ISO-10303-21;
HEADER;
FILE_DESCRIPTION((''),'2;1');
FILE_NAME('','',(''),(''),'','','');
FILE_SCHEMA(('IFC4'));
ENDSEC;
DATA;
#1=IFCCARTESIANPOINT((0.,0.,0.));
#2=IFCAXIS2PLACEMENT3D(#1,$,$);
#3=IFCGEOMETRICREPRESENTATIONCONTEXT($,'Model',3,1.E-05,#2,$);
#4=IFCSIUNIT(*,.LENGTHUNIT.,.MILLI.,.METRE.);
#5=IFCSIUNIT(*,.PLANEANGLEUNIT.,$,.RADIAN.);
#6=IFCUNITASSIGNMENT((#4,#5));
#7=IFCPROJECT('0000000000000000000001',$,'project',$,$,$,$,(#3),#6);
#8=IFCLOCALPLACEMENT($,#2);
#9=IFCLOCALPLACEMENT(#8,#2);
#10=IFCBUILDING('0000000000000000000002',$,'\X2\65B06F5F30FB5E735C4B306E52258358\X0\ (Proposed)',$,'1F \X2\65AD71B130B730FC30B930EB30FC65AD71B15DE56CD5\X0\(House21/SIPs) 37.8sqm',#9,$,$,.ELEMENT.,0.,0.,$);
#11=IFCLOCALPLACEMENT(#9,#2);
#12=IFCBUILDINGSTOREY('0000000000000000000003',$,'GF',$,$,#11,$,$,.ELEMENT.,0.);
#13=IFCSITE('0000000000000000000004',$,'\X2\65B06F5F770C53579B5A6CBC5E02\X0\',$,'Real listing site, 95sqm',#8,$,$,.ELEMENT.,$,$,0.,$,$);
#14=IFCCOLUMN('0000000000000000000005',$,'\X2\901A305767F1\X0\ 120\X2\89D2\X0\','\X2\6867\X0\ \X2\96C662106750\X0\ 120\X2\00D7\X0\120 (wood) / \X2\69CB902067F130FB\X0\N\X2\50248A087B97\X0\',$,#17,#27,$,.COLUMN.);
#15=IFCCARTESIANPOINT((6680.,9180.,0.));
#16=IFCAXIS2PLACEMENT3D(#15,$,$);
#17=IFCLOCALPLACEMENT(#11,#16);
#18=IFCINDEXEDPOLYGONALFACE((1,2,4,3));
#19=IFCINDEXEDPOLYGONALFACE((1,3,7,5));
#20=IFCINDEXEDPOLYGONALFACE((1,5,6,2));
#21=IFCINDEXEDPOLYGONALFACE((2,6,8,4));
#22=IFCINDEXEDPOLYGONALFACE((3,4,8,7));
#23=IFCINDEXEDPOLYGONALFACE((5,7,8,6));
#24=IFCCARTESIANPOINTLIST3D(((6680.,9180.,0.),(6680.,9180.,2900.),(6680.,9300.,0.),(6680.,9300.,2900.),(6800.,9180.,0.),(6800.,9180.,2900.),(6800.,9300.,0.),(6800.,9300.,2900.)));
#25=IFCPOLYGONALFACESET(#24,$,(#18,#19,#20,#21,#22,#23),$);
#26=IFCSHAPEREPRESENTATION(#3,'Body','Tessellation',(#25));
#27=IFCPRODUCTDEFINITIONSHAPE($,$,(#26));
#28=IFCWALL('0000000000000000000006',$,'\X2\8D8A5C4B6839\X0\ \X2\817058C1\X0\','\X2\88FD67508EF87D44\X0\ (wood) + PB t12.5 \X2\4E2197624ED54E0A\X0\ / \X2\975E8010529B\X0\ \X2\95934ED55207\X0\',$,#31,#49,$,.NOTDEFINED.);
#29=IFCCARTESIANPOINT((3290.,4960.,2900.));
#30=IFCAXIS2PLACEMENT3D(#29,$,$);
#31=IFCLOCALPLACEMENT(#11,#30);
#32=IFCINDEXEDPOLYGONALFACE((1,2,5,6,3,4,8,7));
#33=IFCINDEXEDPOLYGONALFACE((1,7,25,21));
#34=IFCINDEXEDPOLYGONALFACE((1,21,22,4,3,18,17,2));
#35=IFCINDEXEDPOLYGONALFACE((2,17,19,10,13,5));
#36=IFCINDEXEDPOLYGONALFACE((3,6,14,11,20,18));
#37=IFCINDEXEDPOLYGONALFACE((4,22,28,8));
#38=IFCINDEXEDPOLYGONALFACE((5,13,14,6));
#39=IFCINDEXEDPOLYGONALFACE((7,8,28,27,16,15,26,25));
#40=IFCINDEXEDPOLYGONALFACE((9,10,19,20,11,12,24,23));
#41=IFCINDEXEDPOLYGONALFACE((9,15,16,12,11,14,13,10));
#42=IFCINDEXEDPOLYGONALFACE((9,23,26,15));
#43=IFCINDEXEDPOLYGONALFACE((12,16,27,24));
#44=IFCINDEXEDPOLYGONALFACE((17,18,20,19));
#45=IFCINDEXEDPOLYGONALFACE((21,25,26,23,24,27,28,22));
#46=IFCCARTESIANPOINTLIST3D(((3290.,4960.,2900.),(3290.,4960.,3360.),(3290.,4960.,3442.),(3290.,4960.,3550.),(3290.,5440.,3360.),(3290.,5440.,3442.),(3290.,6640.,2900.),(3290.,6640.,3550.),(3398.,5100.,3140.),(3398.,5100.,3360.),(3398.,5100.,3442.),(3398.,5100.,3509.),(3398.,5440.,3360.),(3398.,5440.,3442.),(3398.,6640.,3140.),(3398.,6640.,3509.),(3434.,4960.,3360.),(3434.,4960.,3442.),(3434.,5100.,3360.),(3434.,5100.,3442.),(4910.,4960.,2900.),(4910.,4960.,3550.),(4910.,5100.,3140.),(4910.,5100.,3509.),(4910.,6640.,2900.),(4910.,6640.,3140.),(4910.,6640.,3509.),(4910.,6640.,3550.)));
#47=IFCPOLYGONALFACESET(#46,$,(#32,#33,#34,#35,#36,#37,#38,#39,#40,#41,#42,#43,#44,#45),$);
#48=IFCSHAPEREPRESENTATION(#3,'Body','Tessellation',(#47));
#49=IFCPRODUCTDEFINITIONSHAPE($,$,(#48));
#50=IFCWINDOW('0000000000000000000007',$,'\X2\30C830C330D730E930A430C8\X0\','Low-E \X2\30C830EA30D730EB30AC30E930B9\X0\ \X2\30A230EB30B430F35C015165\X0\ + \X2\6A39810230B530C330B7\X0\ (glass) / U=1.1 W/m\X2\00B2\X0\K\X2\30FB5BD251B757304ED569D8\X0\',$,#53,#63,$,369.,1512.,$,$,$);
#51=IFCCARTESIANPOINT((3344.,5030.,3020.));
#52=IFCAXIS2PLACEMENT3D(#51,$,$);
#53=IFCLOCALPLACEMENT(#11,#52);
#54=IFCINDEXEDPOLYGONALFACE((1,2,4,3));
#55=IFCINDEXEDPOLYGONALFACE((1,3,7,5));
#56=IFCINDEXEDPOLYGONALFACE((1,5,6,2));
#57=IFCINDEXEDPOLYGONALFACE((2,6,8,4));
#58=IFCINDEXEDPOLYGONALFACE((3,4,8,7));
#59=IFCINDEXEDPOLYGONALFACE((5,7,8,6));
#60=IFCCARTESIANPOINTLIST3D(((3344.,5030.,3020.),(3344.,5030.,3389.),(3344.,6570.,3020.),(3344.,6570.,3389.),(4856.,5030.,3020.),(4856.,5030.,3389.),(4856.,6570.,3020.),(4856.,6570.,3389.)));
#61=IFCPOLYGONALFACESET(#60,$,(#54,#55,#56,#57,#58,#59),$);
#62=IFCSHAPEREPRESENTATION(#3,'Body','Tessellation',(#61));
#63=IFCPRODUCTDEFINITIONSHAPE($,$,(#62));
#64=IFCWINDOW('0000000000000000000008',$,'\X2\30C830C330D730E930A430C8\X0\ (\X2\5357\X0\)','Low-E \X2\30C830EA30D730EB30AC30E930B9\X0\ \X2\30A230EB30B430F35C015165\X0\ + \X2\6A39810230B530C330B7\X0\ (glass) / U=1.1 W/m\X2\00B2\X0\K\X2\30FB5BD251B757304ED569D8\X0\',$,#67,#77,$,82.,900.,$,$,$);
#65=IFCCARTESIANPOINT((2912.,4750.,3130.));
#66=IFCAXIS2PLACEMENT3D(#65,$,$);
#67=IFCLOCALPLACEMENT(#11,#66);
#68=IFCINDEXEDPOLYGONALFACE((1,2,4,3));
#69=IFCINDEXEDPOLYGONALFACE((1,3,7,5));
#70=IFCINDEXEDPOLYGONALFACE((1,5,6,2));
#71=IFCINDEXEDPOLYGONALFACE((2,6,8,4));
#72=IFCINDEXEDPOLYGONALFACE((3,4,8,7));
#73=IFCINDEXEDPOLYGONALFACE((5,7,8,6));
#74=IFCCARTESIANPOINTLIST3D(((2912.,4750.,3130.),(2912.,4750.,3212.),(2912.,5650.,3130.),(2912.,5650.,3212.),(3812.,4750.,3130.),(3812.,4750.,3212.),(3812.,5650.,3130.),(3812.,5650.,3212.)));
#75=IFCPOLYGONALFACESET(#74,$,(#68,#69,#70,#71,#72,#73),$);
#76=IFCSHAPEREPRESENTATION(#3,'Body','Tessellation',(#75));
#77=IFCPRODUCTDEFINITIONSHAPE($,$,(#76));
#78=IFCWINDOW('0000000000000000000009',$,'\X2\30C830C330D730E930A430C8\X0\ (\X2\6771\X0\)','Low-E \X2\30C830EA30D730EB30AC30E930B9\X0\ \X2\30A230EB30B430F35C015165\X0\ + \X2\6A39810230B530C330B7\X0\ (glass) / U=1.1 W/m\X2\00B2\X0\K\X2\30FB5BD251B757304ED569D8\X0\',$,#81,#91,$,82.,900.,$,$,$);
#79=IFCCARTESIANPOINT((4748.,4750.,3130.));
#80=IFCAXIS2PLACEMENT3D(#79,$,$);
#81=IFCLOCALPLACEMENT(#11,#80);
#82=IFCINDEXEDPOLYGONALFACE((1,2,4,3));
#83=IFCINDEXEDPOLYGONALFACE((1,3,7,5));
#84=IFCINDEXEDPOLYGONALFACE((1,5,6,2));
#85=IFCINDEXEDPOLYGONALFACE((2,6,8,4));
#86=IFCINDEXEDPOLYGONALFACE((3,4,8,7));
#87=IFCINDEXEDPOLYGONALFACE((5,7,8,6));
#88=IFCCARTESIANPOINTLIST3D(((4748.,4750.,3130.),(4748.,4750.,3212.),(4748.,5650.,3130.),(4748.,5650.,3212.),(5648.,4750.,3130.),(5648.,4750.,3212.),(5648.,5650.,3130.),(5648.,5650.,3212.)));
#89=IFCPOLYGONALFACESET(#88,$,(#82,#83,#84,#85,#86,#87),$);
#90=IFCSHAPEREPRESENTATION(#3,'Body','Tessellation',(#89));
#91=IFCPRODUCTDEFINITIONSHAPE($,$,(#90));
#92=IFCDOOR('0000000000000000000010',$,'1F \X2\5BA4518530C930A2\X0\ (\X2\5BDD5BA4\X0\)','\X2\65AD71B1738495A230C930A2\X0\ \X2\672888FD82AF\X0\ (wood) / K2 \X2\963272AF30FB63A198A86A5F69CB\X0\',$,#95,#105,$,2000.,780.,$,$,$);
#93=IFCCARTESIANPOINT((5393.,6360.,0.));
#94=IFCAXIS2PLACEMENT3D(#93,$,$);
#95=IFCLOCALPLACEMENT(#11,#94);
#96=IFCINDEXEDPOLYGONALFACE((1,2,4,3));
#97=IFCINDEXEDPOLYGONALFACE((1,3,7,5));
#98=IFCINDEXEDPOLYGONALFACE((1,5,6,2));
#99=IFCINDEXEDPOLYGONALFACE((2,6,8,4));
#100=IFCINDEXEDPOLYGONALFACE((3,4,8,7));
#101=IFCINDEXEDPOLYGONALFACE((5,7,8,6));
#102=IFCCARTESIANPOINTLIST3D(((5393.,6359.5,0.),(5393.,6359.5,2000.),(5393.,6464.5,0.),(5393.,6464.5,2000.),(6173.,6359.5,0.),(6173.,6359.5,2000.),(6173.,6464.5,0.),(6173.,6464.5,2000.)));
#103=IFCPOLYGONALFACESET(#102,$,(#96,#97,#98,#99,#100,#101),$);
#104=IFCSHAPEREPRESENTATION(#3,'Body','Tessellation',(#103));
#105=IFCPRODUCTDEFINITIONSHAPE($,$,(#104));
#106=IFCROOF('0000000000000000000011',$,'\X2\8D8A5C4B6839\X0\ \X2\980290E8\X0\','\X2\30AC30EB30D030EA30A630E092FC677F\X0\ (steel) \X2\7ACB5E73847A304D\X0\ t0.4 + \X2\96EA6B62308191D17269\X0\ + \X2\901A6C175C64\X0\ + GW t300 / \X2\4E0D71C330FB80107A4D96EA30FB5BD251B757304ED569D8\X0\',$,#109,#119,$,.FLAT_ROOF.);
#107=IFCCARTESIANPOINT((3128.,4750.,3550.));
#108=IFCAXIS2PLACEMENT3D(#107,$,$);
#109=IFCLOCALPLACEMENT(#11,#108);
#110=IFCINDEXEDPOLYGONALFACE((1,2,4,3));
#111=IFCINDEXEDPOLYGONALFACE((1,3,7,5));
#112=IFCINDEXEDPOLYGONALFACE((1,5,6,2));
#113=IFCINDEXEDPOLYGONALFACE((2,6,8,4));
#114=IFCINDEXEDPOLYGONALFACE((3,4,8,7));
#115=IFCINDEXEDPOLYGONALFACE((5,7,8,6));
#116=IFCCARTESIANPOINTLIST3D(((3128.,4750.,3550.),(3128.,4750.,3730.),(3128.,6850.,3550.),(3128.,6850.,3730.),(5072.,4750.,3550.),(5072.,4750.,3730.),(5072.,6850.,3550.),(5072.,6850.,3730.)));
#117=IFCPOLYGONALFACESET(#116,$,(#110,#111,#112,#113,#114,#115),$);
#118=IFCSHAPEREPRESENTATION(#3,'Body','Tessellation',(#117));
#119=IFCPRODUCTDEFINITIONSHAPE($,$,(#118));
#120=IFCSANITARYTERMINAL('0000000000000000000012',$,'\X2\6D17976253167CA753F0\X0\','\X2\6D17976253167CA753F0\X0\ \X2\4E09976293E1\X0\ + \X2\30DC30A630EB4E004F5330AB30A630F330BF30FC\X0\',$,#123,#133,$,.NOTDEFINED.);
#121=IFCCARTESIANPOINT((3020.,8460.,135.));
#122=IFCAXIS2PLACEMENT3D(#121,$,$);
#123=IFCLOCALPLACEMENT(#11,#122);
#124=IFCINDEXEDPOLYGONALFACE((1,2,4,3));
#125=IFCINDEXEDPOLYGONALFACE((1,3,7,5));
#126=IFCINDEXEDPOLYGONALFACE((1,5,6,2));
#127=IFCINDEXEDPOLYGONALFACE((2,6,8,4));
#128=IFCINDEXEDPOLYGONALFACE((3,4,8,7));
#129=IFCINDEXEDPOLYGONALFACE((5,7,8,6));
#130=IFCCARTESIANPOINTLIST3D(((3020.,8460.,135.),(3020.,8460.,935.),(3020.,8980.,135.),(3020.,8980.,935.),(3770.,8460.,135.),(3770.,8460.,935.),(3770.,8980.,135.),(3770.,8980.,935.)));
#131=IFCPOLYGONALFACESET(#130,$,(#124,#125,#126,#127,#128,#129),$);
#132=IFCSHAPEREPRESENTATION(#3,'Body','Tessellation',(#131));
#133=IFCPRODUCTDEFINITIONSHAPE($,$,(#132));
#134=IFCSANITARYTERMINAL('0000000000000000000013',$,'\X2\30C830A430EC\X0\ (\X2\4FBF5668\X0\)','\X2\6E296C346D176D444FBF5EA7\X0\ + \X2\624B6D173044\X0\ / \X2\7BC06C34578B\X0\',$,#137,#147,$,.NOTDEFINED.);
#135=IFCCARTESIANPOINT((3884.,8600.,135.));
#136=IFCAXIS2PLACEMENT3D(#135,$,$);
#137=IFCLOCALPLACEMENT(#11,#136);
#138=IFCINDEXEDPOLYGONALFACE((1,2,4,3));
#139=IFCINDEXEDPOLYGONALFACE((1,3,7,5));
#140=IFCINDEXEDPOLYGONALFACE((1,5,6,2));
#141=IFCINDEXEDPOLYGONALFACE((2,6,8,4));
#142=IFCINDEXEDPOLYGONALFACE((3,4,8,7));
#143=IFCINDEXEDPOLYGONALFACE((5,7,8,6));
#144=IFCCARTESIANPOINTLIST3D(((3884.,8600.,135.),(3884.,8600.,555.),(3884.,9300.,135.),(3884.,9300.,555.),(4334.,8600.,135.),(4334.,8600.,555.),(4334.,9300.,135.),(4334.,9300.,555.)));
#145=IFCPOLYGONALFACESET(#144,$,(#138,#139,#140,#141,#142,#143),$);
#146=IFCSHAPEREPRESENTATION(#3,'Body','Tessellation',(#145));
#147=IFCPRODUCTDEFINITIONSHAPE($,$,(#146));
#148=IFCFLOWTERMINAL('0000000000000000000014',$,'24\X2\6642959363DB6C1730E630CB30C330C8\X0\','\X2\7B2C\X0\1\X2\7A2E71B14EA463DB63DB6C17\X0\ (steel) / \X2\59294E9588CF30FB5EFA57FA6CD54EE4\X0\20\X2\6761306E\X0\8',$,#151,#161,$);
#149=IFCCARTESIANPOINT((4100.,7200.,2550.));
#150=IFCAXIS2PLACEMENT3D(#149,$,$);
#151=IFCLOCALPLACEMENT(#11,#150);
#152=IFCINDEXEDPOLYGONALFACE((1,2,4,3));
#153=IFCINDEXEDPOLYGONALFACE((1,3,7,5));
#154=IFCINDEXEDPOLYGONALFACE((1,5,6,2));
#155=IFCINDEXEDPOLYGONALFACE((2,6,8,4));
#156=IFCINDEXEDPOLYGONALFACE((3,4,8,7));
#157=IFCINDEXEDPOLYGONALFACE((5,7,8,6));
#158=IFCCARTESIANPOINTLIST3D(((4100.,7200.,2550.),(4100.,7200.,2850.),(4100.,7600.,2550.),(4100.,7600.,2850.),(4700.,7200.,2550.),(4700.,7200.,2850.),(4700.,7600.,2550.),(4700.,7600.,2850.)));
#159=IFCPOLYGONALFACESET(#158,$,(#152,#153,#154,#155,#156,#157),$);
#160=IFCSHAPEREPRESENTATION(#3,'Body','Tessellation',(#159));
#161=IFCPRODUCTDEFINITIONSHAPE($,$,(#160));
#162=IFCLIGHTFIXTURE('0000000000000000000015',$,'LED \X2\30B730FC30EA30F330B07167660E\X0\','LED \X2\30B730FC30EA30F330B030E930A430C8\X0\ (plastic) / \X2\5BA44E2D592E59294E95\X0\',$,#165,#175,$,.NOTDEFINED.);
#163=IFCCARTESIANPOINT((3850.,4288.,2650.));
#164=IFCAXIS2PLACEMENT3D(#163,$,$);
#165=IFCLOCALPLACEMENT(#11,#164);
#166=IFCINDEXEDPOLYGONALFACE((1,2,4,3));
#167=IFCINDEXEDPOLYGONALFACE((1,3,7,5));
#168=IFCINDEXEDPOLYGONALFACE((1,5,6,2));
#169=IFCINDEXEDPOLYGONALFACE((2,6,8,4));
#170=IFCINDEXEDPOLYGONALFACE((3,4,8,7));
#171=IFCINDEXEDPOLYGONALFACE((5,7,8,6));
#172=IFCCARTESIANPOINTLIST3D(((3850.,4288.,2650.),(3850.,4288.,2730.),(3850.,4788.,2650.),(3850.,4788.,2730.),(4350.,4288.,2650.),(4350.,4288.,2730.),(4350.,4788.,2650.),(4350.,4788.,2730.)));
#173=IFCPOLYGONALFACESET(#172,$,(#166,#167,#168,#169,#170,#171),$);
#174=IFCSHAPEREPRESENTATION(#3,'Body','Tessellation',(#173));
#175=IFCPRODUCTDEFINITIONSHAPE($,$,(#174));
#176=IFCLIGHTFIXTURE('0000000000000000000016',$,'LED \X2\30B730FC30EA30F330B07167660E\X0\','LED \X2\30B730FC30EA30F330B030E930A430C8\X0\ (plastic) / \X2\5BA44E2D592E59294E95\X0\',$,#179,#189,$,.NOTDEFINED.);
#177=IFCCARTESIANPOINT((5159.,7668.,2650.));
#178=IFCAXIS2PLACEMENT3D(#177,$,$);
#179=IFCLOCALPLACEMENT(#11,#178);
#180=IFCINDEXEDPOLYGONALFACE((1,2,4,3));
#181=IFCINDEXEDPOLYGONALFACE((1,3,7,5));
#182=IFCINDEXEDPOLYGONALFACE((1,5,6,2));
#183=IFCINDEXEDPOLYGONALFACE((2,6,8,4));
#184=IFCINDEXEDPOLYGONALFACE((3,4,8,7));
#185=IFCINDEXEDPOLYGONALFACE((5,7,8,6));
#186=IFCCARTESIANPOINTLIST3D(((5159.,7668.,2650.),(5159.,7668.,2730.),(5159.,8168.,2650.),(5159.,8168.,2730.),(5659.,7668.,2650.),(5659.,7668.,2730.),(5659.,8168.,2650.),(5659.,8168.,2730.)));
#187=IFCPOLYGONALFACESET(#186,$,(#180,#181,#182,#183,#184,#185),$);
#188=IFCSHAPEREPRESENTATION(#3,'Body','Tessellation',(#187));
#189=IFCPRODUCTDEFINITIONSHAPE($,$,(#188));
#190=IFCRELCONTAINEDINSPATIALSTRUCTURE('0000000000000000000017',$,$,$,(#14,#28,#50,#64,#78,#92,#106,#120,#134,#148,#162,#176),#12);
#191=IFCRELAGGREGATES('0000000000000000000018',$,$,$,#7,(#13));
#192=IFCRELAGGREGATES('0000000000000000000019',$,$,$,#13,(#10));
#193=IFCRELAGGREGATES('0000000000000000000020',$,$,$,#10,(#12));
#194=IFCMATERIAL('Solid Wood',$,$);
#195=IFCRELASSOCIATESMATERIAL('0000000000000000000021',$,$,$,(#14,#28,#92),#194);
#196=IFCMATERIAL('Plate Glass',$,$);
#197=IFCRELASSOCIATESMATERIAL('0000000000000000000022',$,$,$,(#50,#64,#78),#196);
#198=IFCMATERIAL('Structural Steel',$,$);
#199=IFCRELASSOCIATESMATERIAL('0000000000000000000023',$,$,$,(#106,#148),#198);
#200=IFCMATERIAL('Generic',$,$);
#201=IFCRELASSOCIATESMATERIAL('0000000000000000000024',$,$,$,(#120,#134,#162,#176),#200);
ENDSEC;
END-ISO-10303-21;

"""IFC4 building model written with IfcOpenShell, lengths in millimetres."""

from ifc_helpers import new_model, si_unit, frame, frame_2d, origin, place, context, project, spatial, rectangle, extrude, material, element, fill, save


model = new_model("IFC4")

# Units and contexts
model_context = context("Model", 3, precision=1e-05, world=origin())
ifc_project = project(units=[si_unit("LENGTHUNIT", "METRE", prefix="MILLI"), si_unit("PLANEANGLEUNIT", "RADIAN")], contexts=[model_context])

# Site, building, storey
site_placement = place(None, origin())
site = spatial("IfcSite", under=ifc_project, at=site_placement, Name="新潟県南魚沼市", ObjectType="Real listing site, 95sqm", CompositionType="ELEMENT", RefElevation=0.0)
building_placement = place(site_placement, origin())
building = spatial("IfcBuilding", under=site, at=building_placement, Name="新潟・平屋の別荘 (Proposed)", ObjectType="1F 断熱シースルー断熱工法(House21/SIPs) 37.8sqm", CompositionType="ELEMENT", ElevationOfRefHeight=0.0, ElevationOfTerrain=0.0)
storey_placement = place(building_placement, origin())
storey = spatial("IfcBuildingStorey", under=building, at=storey_placement, Name="GF", CompositionType="ELEMENT", Elevation=0.0)

# Column
ifc_material_1 = material(Name="Solid Wood")
column_1_placement = place(storey_placement, frame((6680.0, 9180.0, 0.0)))
element("IfcColumn", 1, at=column_1_placement, inside=storey, material=ifc_material_1, Name="通し柱 120角", Description="桧 集成材 120×120 (wood) / 構造柱・N値計算", PredefinedType="COLUMN", context=model_context, shape_type="SweptSolid", body=[
    extrude(rectangle(XDim=120.0, YDim=120.0, at=frame_2d((60.0, 60.0))), frame((6680.0, 9180.0, 0.0)), (0.0, 0.0, 1.0), 2900.0),
])

# Wall, openings, windows
wall_1_placement = place(storey_placement, frame((3290.0, 4960.0, 2900.0)))
wall_1 = element("IfcWall", 2, at=wall_1_placement, inside=storey, material=ifc_material_1, Name="越屋根 腰壁", Description="製材軸組 (wood) + PB t12.5 両面仕上 / 非耐力 間仕切", PredefinedType="NOTDEFINED", context=model_context, shape_type="SweptSolid", body=[
    extrude(rectangle(XDim=1620.0, YDim=1680.0, at=frame_2d((810.0, 840.0))), frame((3290.0, 4960.0, 2900.0)), (0.0, 0.0, 1.0), 650.0),
])
opening_1_placement = place(storey_placement, frame((3344.0, 5030.0, 3020.0)))
opening_1 = element("IfcOpeningElement", 3, at=opening_1_placement, cuts=wall_1, PredefinedType="NOTDEFINED", context=model_context, shape_type="SweptSolid", body=[
    extrude(rectangle(XDim=1512.0, YDim=1540.0, at=frame_2d((756.0, 770.0))), frame((3344.0, 5030.0, 3020.0)), (0.0, 0.0, 1.0), 369.0),
])
opening_2_placement = place(storey_placement, frame((2912.0, 4750.0, 3130.0)))
opening_2 = element("IfcOpeningElement", 4, at=opening_2_placement, cuts=wall_1, PredefinedType="NOTDEFINED", context=model_context, shape_type="SweptSolid", body=[
    extrude(rectangle(XDim=900.0, YDim=900.0, at=frame_2d((450.0, 450.0))), frame((2912.0, 4750.0, 3130.0)), (0.0, 0.0, 1.0), 82.0),
])
opening_3_placement = place(storey_placement, frame((4748.0, 4750.0, 3130.0)))
opening_3 = element("IfcOpeningElement", 5, at=opening_3_placement, cuts=wall_1, PredefinedType="NOTDEFINED", context=model_context, shape_type="SweptSolid", body=[
    extrude(rectangle(XDim=900.0, YDim=900.0, at=frame_2d((450.0, 450.0))), frame((4748.0, 4750.0, 3130.0)), (0.0, 0.0, 1.0), 82.0),
])
ifc_material_2 = material(Name="Plate Glass")
window_1_placement = place(storey_placement, frame((3344.0, 5030.0, 3020.0)))
window_1 = element("IfcWindow", 6, at=window_1_placement, inside=storey, material=ifc_material_2, Name="トップライト", Description="Low-E トリプルガラス アルゴン封入 + 樹脂サッシ (glass) / U=1.1 W/m²K・寒冷地仕様", OverallHeight=369.0, OverallWidth=1512.0, context=model_context, shape_type="SweptSolid", body=[
    extrude(rectangle(XDim=1512.0, YDim=1540.0, at=frame_2d((756.0, 770.0))), frame((3344.0, 5030.0, 3020.0)), (0.0, 0.0, 1.0), 369.0),
])
fill(opening_1, window_1)
window_2_placement = place(storey_placement, frame((2912.0, 4750.0, 3130.0)))
window_2 = element("IfcWindow", 7, at=window_2_placement, inside=storey, material=ifc_material_2, Name="トップライト (南)", Description="Low-E トリプルガラス アルゴン封入 + 樹脂サッシ (glass) / U=1.1 W/m²K・寒冷地仕様", OverallHeight=82.0, OverallWidth=900.0, context=model_context, shape_type="SweptSolid", body=[
    extrude(rectangle(XDim=900.0, YDim=900.0, at=frame_2d((450.0, 450.0))), frame((2912.0, 4750.0, 3130.0)), (0.0, 0.0, 1.0), 82.0),
])
fill(opening_2, window_2)
window_3_placement = place(storey_placement, frame((4748.0, 4750.0, 3130.0)))
window_3 = element("IfcWindow", 8, at=window_3_placement, inside=storey, material=ifc_material_2, Name="トップライト (東)", Description="Low-E トリプルガラス アルゴン封入 + 樹脂サッシ (glass) / U=1.1 W/m²K・寒冷地仕様", OverallHeight=82.0, OverallWidth=900.0, context=model_context, shape_type="SweptSolid", body=[
    extrude(rectangle(XDim=900.0, YDim=900.0, at=frame_2d((450.0, 450.0))), frame((4748.0, 4750.0, 3130.0)), (0.0, 0.0, 1.0), 82.0),
])
fill(opening_3, window_3)

# Door
door_placement = place(storey_placement, frame((5393.0, 6360.0, 0.0)))
element("IfcDoor", 9, at=door_placement, inside=storey, material=ifc_material_1, Name="1F 室内ドア (寝室)", Description="断熱玄関ドア 木製芯 (wood) / K2 防犯・採風機構", OverallHeight=2000.0, OverallWidth=780.0, context=model_context, shape_type="SweptSolid", body=[
    extrude(rectangle(XDim=780.0, YDim=105.0, at=frame_2d((390.0, 52.0))), frame((5393.0, 6360.0, 0.0)), (0.0, 0.0, 1.0), 2000.0),
])

# Roof
ifc_material_3 = material(Name="Structural Steel")
roof_placement = place(storey_placement, frame((3128.0, 4750.0, 3550.0)))
element("IfcRoof", 10, at=roof_placement, inside=storey, material=ifc_material_3, Name="越屋根 頂部", Description="ガルバリウム鋼板 (steel) 立平葺き t0.4 + 雪止め金物 + 通気層 + GW t300 / 不燃・耐積雪・寒冷地仕様", PredefinedType="FLAT_ROOF", context=model_context, shape_type="SweptSolid", body=[
    extrude(rectangle(XDim=1944.0, YDim=2100.0, at=frame_2d((972.0, 1050.0))), frame((3128.0, 4750.0, 3550.0)), (0.0, 0.0, 1.0), 180.0),
])

# Sanitary terminals
ifc_material_4 = material(Name="Generic")
sanitary_terminal_1_placement = place(storey_placement, frame((3020.0, 8460.0, 135.0)))
element("IfcSanitaryTerminal", 11, at=sanitary_terminal_1_placement, inside=storey, material=ifc_material_4, Name="洗面化粧台", Description="洗面化粧台 三面鏡 + ボウル一体カウンター", PredefinedType="NOTDEFINED", context=model_context, shape_type="SweptSolid", body=[
    extrude(rectangle(XDim=750.0, YDim=520.0, at=frame_2d((375.0, 260.0))), frame((3020.0, 8460.0, 135.0)), (0.0, 0.0, 1.0), 800.0),
])
sanitary_terminal_2_placement = place(storey_placement, frame((3884.0, 8600.0, 135.0)))
element("IfcSanitaryTerminal", 12, at=sanitary_terminal_2_placement, inside=storey, material=ifc_material_4, Name="トイレ (便器)", Description="温水洗浄便座 + 手洗い / 節水型", PredefinedType="NOTDEFINED", context=model_context, shape_type="SweptSolid", body=[
    extrude(rectangle(XDim=450.0, YDim=700.0, at=frame_2d((225.0, 350.0))), frame((3884.0, 8600.0, 135.0)), (0.0, 0.0, 1.0), 420.0),
])

# Flow terminal
flow_terminal_placement = place(storey_placement, frame((4100.0, 7200.0, 2550.0)))
element("IfcFlowTerminal", 13, at=flow_terminal_placement, inside=storey, material=ifc_material_3, Name="24時間換気ユニット", Description="第1種熱交換換気 (steel) / 天井裏・建基法令20条の8", context=model_context, shape_type="SweptSolid", body=[
    extrude(rectangle(XDim=600.0, YDim=400.0, at=frame_2d((300.0, 200.0))), frame((4100.0, 7200.0, 2550.0)), (0.0, 0.0, 1.0), 300.0),
])

# Light fixtures
light_fixture_1_placement = place(storey_placement, frame((3850.0, 4288.0, 2650.0)))
element("IfcLightFixture", 14, at=light_fixture_1_placement, inside=storey, material=ifc_material_4, Name="LED シーリング照明", Description="LED シーリングライト (plastic) / 室中央天井", PredefinedType="NOTDEFINED", context=model_context, shape_type="SweptSolid", body=[
    extrude(rectangle(XDim=500.0, YDim=500.0, at=frame_2d((250.0, 250.0))), frame((3850.0, 4288.0, 2650.0)), (0.0, 0.0, 1.0), 80.0),
])
light_fixture_2_placement = place(storey_placement, frame((5159.0, 7668.0, 2650.0)))
element("IfcLightFixture", 15, at=light_fixture_2_placement, inside=storey, material=ifc_material_4, Name="LED シーリング照明", Description="LED シーリングライト (plastic) / 室中央天井", PredefinedType="NOTDEFINED", context=model_context, shape_type="SweptSolid", body=[
    extrude(rectangle(XDim=500.0, YDim=500.0, at=frame_2d((250.0, 250.0))), frame((5159.0, 7668.0, 2650.0)), (0.0, 0.0, 1.0), 80.0),
])

save(model, "model.ifc")
